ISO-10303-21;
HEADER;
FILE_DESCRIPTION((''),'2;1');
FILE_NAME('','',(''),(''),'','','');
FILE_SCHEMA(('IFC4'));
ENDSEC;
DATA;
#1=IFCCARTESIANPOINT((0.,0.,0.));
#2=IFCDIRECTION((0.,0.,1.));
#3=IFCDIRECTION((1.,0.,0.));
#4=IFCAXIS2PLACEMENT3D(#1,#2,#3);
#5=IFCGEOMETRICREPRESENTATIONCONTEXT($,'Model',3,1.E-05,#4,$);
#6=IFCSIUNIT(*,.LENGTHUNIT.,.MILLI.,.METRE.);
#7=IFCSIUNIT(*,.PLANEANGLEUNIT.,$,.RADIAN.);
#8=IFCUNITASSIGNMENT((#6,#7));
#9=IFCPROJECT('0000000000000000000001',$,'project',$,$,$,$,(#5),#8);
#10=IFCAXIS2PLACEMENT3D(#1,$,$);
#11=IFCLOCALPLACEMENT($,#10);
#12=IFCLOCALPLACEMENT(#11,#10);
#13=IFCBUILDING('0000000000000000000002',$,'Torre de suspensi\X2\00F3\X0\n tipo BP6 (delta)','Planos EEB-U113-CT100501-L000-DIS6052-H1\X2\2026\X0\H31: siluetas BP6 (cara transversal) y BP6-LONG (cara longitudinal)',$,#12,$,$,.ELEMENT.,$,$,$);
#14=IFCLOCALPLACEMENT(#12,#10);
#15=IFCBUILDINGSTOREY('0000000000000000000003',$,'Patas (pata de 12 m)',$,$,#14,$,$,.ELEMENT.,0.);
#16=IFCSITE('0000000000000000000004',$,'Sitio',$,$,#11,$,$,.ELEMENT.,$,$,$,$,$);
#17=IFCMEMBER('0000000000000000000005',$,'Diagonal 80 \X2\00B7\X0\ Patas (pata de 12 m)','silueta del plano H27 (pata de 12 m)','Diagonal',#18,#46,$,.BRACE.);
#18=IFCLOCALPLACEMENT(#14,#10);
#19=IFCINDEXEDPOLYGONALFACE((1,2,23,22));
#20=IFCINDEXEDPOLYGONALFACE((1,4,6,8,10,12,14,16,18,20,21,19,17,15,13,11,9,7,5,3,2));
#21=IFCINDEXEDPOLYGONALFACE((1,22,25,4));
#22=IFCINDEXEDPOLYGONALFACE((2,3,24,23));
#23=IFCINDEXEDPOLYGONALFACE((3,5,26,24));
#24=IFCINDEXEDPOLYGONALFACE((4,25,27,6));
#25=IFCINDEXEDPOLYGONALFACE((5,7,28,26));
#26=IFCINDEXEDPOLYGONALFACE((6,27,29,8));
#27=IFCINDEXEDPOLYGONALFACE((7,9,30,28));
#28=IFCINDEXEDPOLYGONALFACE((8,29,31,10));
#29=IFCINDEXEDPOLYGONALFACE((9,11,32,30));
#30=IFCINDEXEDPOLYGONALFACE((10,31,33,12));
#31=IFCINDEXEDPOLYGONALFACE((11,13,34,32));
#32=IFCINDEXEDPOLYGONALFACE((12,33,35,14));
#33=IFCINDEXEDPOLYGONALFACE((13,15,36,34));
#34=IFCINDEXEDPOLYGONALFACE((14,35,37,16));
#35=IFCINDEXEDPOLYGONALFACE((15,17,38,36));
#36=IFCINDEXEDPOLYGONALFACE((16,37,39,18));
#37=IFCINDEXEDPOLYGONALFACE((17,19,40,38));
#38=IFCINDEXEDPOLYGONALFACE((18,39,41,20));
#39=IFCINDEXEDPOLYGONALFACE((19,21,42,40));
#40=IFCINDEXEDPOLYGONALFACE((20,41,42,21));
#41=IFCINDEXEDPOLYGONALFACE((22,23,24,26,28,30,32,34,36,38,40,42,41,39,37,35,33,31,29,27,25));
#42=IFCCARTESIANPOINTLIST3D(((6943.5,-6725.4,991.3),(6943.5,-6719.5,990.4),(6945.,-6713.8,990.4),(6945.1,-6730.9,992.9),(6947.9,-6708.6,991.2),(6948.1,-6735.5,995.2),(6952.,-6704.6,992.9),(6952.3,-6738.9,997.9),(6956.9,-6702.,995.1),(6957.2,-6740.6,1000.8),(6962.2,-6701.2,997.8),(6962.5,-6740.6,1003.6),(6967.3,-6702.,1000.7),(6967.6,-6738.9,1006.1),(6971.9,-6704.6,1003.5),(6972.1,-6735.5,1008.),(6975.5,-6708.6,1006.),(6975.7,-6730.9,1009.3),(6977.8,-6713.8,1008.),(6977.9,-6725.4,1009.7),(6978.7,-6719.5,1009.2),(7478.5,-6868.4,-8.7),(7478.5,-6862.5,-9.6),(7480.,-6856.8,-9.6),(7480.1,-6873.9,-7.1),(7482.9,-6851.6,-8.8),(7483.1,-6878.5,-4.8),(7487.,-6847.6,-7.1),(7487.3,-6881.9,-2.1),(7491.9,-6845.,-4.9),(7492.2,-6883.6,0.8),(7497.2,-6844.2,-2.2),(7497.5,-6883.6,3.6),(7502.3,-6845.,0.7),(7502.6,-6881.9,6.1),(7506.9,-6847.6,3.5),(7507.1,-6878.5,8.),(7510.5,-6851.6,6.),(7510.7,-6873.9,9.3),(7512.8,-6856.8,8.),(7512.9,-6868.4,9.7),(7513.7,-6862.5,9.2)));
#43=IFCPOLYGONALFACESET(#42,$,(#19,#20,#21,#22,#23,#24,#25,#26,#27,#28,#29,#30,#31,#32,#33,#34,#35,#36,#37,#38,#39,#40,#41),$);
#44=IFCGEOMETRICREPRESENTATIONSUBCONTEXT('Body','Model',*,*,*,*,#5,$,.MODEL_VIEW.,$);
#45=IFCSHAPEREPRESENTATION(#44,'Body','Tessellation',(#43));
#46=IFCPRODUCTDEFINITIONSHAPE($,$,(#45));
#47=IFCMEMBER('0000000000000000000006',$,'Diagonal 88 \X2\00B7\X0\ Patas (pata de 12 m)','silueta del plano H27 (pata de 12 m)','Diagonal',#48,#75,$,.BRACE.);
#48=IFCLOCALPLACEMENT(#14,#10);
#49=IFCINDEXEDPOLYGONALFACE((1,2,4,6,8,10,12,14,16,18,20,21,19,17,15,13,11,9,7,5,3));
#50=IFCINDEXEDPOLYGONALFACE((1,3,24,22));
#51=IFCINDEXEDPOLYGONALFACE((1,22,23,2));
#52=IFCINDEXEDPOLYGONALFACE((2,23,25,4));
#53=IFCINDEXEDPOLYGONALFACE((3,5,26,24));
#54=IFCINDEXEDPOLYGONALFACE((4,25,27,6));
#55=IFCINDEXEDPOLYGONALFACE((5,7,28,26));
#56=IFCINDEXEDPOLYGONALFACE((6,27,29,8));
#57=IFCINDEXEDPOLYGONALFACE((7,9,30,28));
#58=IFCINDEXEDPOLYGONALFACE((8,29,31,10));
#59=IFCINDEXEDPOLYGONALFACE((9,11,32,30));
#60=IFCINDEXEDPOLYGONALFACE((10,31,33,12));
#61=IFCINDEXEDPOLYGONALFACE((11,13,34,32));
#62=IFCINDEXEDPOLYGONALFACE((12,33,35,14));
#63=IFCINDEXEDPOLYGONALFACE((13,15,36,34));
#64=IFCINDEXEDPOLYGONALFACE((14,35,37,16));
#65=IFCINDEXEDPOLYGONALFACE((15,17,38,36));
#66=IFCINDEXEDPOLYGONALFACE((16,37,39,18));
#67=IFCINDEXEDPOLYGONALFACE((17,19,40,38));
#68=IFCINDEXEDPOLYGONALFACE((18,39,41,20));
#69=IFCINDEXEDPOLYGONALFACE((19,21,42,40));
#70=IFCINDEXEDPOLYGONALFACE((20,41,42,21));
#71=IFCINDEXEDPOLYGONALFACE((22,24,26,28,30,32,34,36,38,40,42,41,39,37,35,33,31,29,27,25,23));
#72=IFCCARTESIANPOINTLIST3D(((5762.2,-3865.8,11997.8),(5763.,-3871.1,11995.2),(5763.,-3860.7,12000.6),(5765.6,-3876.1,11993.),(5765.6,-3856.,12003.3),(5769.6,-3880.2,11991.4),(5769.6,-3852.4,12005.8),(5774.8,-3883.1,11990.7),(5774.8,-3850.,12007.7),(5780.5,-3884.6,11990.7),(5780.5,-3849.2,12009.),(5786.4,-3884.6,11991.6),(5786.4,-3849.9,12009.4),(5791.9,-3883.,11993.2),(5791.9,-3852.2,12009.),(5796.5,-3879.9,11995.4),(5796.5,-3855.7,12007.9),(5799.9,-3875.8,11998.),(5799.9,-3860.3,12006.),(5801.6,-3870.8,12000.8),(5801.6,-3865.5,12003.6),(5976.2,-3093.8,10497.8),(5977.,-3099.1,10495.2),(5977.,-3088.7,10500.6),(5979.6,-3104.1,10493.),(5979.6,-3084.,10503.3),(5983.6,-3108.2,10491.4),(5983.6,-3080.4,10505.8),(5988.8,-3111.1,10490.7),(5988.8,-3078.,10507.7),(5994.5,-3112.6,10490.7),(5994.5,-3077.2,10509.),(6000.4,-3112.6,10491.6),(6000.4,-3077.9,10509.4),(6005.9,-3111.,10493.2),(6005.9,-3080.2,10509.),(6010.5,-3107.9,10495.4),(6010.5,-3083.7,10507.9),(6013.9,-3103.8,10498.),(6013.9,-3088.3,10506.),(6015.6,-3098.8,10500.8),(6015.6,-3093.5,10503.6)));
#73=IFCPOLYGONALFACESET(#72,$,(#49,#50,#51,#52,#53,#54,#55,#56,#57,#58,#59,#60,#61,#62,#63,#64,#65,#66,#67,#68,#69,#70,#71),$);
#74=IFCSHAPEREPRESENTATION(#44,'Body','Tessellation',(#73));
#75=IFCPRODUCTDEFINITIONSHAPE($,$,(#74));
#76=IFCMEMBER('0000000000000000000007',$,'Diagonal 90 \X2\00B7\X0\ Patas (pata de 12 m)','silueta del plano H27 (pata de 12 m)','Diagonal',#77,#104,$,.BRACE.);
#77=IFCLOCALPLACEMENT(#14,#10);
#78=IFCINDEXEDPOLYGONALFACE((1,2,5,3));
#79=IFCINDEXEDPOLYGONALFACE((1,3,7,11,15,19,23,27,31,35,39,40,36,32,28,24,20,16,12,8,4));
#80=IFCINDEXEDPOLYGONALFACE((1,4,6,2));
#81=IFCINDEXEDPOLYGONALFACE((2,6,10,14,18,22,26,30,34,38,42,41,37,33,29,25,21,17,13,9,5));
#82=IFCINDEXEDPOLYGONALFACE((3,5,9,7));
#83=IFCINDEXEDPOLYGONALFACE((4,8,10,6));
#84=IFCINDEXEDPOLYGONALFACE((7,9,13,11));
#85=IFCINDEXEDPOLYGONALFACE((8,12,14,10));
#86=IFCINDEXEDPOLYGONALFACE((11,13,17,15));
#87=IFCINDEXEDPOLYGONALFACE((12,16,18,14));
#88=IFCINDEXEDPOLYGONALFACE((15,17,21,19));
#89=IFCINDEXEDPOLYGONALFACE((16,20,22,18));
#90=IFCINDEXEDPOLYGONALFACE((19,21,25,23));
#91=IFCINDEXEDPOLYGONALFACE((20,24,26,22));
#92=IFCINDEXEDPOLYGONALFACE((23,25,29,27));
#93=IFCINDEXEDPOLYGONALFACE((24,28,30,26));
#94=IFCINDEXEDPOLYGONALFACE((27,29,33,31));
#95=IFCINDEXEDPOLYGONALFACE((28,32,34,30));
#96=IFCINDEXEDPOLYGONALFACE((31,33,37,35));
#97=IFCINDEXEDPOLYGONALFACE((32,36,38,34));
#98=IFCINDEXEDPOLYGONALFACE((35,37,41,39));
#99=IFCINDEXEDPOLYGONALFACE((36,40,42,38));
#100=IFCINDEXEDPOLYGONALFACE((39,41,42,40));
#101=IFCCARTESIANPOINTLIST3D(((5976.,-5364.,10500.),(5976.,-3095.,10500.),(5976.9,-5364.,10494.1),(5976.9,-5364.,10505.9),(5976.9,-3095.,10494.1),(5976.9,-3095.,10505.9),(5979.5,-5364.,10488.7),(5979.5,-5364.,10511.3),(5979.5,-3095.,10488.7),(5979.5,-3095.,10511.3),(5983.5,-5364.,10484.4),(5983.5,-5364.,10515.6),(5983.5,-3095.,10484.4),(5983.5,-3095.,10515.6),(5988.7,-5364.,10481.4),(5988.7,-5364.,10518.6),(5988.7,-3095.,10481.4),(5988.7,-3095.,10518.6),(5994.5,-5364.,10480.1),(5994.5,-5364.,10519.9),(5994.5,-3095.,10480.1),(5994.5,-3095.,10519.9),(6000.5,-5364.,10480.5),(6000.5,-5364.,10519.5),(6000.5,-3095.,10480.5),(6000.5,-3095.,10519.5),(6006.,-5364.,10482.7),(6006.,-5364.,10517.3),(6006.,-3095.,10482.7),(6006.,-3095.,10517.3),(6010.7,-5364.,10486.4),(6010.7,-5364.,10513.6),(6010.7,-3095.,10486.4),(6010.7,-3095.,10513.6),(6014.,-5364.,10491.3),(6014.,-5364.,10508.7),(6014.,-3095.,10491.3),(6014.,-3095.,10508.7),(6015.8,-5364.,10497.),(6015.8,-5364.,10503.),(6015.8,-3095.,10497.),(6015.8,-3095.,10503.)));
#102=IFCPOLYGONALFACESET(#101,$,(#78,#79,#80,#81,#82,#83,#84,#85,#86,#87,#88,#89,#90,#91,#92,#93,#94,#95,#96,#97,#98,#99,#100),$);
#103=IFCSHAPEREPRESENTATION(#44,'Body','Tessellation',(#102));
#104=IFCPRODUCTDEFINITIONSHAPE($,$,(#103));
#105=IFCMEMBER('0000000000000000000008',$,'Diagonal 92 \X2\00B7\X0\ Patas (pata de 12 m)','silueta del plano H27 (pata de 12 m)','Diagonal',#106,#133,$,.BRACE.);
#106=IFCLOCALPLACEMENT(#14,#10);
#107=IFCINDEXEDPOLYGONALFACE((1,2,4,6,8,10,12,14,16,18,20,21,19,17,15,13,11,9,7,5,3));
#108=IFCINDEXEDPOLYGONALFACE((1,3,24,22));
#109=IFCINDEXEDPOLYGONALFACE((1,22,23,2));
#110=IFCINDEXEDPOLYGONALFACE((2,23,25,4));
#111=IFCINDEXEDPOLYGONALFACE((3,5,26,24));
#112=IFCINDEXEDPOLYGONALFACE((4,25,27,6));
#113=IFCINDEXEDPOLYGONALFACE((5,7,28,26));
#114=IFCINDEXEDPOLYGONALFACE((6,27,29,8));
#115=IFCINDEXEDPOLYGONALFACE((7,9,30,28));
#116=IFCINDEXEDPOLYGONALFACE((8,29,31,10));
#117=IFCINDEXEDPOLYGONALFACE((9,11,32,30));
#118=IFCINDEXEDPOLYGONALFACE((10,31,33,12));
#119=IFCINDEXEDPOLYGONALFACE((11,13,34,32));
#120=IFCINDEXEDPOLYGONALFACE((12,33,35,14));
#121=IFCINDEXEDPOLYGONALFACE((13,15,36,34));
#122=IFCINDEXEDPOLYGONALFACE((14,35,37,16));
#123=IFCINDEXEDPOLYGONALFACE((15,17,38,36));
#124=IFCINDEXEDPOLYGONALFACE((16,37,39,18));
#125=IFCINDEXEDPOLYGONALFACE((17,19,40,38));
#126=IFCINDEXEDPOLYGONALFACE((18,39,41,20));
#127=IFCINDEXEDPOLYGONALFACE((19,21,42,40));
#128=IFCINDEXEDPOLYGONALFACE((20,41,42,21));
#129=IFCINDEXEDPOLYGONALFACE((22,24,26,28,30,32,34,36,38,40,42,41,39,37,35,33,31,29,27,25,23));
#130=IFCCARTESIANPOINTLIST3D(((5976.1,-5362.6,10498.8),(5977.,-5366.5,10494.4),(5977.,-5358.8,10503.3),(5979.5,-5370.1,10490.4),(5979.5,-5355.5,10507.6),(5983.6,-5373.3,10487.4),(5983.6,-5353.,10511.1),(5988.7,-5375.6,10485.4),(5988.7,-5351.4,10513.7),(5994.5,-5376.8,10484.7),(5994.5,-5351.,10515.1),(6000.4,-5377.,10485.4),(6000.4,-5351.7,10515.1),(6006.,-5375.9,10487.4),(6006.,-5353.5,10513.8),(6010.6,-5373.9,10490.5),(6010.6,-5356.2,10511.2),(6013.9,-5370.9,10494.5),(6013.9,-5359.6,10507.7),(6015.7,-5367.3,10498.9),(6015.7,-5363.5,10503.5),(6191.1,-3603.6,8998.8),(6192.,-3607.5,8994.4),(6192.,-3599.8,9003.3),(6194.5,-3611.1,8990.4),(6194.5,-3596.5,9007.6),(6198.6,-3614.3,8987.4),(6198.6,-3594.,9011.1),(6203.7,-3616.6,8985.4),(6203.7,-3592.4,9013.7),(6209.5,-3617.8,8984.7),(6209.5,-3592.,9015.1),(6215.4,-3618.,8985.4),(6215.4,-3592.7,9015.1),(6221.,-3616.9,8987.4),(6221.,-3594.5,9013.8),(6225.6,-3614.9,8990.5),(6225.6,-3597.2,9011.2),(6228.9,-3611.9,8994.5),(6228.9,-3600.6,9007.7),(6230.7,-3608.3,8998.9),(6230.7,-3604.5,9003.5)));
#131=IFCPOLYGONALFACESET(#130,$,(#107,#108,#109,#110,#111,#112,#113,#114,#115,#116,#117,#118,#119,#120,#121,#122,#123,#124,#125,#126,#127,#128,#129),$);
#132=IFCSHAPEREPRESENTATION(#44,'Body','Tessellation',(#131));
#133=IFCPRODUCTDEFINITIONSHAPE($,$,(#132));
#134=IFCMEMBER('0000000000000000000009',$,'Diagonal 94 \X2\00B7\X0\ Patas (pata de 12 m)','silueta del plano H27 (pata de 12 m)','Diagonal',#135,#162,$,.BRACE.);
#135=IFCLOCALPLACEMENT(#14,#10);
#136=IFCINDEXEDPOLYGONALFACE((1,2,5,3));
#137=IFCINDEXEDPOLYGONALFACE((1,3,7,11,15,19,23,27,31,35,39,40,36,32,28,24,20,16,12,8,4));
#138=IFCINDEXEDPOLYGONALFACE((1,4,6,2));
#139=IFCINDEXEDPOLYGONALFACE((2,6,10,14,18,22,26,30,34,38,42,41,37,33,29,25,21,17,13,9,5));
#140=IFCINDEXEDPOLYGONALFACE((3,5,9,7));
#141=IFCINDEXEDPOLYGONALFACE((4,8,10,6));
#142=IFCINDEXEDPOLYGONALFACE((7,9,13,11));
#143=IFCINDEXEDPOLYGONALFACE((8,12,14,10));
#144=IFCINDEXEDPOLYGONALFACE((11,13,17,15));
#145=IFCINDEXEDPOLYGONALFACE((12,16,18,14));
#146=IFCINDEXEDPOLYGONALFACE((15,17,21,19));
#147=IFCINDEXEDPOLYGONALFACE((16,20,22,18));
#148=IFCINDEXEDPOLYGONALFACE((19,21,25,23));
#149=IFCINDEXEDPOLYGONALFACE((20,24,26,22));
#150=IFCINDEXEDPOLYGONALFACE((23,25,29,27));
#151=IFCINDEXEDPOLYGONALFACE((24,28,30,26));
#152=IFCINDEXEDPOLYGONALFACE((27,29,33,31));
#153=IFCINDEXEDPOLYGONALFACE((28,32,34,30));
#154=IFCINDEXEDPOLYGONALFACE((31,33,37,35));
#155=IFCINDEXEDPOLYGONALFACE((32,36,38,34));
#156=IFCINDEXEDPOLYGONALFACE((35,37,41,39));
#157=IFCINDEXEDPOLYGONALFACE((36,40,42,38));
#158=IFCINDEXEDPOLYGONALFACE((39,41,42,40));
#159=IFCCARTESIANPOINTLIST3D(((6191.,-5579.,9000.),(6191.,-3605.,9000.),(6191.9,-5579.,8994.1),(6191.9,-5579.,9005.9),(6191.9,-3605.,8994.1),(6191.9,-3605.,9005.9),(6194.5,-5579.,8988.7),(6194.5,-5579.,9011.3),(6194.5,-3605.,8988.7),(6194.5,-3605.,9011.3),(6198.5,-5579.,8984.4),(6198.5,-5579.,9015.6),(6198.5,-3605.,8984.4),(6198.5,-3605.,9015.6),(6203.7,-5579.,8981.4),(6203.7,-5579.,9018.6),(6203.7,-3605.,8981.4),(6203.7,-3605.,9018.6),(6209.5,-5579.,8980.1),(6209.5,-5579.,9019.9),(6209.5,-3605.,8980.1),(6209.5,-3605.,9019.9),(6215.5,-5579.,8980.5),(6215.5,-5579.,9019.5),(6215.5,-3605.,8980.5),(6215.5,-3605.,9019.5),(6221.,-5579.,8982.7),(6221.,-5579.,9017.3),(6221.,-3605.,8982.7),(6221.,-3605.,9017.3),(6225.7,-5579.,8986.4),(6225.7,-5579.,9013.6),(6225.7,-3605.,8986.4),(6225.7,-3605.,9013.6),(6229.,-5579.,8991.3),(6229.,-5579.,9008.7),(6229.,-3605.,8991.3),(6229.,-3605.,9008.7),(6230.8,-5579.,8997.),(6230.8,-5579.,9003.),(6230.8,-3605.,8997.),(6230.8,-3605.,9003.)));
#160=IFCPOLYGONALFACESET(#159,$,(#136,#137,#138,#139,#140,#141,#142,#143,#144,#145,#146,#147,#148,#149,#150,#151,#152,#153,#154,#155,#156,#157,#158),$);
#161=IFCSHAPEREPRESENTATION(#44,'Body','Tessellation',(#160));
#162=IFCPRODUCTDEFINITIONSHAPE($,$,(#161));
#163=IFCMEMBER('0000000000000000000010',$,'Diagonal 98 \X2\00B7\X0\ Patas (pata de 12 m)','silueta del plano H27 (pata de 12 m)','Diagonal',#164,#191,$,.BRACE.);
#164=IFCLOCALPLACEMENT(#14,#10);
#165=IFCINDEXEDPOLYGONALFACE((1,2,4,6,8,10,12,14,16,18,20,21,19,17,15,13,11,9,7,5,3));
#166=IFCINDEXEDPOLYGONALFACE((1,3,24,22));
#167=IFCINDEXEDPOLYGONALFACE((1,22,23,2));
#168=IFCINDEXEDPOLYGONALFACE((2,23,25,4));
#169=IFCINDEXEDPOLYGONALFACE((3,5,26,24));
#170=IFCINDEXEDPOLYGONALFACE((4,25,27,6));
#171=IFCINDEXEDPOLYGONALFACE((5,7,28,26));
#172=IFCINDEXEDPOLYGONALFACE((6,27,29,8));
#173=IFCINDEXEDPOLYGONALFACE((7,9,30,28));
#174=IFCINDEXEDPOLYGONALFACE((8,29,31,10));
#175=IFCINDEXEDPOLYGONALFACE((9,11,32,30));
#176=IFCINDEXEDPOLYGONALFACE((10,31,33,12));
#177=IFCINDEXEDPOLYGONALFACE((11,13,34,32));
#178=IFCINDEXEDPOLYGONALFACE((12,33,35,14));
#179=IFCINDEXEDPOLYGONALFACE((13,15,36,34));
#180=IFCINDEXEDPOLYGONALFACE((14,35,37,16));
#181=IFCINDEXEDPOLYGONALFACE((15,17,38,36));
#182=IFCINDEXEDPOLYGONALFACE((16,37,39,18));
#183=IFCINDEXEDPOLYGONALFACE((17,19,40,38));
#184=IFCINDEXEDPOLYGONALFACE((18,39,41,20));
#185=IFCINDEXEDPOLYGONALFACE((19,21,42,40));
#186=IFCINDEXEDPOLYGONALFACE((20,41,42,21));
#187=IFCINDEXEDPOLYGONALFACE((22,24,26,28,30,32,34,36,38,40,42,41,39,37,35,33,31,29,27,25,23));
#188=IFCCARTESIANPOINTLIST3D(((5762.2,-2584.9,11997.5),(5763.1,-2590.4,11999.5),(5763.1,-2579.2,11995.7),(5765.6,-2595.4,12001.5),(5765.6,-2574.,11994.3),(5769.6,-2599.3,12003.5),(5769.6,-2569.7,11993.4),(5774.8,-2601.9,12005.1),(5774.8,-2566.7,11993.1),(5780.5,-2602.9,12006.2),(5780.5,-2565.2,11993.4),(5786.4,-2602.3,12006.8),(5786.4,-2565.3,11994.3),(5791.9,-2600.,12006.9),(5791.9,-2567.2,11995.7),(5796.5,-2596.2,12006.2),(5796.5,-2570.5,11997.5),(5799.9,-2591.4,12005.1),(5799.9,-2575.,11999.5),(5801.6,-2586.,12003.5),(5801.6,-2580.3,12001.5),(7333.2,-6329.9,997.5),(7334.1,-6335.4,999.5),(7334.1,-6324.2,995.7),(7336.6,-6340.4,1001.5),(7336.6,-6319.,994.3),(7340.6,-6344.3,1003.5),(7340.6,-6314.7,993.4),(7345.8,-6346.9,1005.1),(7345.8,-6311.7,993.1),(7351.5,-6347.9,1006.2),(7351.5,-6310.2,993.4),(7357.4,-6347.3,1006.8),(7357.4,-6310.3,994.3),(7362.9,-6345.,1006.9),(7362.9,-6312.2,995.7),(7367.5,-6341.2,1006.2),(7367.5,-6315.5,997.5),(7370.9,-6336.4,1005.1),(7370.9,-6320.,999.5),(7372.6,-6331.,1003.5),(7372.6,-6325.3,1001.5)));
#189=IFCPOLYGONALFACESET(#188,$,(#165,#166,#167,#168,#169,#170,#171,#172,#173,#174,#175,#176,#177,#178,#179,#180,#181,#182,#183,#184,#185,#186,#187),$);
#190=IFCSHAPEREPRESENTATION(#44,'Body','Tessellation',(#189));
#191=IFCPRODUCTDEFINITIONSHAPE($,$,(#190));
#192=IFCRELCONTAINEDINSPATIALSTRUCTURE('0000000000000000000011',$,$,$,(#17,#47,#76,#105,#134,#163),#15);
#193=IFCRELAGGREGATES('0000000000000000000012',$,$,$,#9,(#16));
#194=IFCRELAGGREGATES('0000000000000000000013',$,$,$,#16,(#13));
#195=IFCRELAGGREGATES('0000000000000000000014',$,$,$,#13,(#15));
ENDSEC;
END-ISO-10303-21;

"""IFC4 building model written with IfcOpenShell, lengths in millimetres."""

from ifc_helpers import new_model, si_unit, frame, origin, origin_with_axes, place, context, subcontext, project, spatial, circle, extrude, element, save


model = new_model("IFC4")

# Units and contexts
model_context = context("Model", 3, precision=1e-05, world=origin_with_axes())
body_context = subcontext(model_context, "Body", "Model", "MODEL_VIEW")
ifc_project = project(units=[si_unit("LENGTHUNIT", "METRE", prefix="MILLI"), si_unit("PLANEANGLEUNIT", "RADIAN")], contexts=[model_context])

# Site, building, storey
site_placement = place(None, origin())
site = spatial("IfcSite", under=ifc_project, at=site_placement, Name="Sitio", CompositionType="ELEMENT")
building_placement = place(site_placement, origin())
building = spatial("IfcBuilding", under=site, at=building_placement, Name="Torre de suspensión tipo BP6 (delta)", Description="Planos EEB-U113-CT100501-L000-DIS6052-H1…H31: siluetas BP6 (cara transversal) y BP6-LONG (cara longitudinal)", CompositionType="ELEMENT")
storey_placement = place(building_placement, origin())
storey = spatial("IfcBuildingStorey", under=building, at=storey_placement, Name="Patas (pata de 12 m)", CompositionType="ELEMENT", Elevation=0.0)

# Members
member_1_placement = place(storey_placement, frame((7496.0, -6864.0, 0.0), z_axis=(-0.468026, 0.125099, 0.874815), x_axis=(0.059013, 0.992144, -0.110305)))
element("IfcMember", 1, at=member_1_placement, inside=storey, Name="Diagonal 80 · Patas (pata de 12 m)", Description="silueta del plano H27 (pata de 12 m)", ObjectType="Diagonal", PredefinedType="BRACE", context=body_context, shape_type="SweptSolid", body=[
    extrude(circle(Radius=20.0), None, (0.0, 0.0, 1.0), 1143.1),
])
member_2_placement = place(storey_placement, frame((5782.0, -3867.0, 12000.0), z_axis=(0.125844, 0.453978, -0.882081), x_axis=(-0.99205, 0.057588, -0.111894)))
element("IfcMember", 2, at=member_2_placement, inside=storey, Name="Diagonal 88 · Patas (pata de 12 m)", Description="silueta del plano H27 (pata de 12 m)", ObjectType="Diagonal", PredefinedType="BRACE", context=body_context, shape_type="SweptSolid", body=[
    extrude(circle(Radius=20.0), None, (0.0, 0.0, 1.0), 1700.5),
])
member_3_placement = place(storey_placement, frame((5996.0, -3095.0, 10500.0), z_axis=(0.0, -1.0, 0.0), x_axis=(-1.0, 0.0, 0.0)))
element("IfcMember", 3, at=member_3_placement, inside=storey, Name="Diagonal 90 · Patas (pata de 12 m)", Description="silueta del plano H27 (pata de 12 m)", ObjectType="Diagonal", PredefinedType="BRACE", context=body_context, shape_type="SweptSolid", body=[
    extrude(circle(Radius=20.0), None, (0.0, 0.0, 1.0), 2269.0),
])
member_4_placement = place(storey_placement, frame((6211.0, -3605.0, 9000.0), z_axis=(-0.092604, -0.757633, 0.646077), x_axis=(-0.995703, 0.070463, -0.060088)))
element("IfcMember", 4, at=member_4_placement, inside=storey, Name="Diagonal 92 · Patas (pata de 12 m)", Description="silueta del plano H27 (pata de 12 m)", ObjectType="Diagonal", PredefinedType="BRACE", context=body_context, shape_type="SweptSolid", body=[
    extrude(circle(Radius=20.0), None, (0.0, 0.0, 1.0), 2321.7),
])
member_5_placement = place(storey_placement, frame((6211.0, -5579.0, 9000.0), z_axis=(0.0, 1.0, 0.0), x_axis=(-1.0, 0.0, 0.0)))
element("IfcMember", 5, at=member_5_placement, inside=storey, Name="Diagonal 94 · Patas (pata de 12 m)", Description="silueta del plano H27 (pata de 12 m)", ObjectType="Diagonal", PredefinedType="BRACE", context=body_context, shape_type="SweptSolid", body=[
    extrude(circle(Radius=20.0), None, (0.0, 0.0, 1.0), 1974.0),
])
member_6_placement = place(storey_placement, frame((5782.0, -2584.0, 12000.0), z_axis=(0.133979, -0.319383, -0.938107), x_axis=(-0.990984, -0.04318, -0.12683)))
element("IfcMember", 6, at=member_6_placement, inside=storey, Name="Diagonal 98 · Patas (pata de 12 m)", Description="silueta del plano H27 (pata de 12 m)", ObjectType="Diagonal", PredefinedType="BRACE", context=body_context, shape_type="SweptSolid", body=[
    extrude(circle(Radius=20.0), None, (0.0, 0.0, 1.0), 11725.7),
])

save(model, "model.ifc")
